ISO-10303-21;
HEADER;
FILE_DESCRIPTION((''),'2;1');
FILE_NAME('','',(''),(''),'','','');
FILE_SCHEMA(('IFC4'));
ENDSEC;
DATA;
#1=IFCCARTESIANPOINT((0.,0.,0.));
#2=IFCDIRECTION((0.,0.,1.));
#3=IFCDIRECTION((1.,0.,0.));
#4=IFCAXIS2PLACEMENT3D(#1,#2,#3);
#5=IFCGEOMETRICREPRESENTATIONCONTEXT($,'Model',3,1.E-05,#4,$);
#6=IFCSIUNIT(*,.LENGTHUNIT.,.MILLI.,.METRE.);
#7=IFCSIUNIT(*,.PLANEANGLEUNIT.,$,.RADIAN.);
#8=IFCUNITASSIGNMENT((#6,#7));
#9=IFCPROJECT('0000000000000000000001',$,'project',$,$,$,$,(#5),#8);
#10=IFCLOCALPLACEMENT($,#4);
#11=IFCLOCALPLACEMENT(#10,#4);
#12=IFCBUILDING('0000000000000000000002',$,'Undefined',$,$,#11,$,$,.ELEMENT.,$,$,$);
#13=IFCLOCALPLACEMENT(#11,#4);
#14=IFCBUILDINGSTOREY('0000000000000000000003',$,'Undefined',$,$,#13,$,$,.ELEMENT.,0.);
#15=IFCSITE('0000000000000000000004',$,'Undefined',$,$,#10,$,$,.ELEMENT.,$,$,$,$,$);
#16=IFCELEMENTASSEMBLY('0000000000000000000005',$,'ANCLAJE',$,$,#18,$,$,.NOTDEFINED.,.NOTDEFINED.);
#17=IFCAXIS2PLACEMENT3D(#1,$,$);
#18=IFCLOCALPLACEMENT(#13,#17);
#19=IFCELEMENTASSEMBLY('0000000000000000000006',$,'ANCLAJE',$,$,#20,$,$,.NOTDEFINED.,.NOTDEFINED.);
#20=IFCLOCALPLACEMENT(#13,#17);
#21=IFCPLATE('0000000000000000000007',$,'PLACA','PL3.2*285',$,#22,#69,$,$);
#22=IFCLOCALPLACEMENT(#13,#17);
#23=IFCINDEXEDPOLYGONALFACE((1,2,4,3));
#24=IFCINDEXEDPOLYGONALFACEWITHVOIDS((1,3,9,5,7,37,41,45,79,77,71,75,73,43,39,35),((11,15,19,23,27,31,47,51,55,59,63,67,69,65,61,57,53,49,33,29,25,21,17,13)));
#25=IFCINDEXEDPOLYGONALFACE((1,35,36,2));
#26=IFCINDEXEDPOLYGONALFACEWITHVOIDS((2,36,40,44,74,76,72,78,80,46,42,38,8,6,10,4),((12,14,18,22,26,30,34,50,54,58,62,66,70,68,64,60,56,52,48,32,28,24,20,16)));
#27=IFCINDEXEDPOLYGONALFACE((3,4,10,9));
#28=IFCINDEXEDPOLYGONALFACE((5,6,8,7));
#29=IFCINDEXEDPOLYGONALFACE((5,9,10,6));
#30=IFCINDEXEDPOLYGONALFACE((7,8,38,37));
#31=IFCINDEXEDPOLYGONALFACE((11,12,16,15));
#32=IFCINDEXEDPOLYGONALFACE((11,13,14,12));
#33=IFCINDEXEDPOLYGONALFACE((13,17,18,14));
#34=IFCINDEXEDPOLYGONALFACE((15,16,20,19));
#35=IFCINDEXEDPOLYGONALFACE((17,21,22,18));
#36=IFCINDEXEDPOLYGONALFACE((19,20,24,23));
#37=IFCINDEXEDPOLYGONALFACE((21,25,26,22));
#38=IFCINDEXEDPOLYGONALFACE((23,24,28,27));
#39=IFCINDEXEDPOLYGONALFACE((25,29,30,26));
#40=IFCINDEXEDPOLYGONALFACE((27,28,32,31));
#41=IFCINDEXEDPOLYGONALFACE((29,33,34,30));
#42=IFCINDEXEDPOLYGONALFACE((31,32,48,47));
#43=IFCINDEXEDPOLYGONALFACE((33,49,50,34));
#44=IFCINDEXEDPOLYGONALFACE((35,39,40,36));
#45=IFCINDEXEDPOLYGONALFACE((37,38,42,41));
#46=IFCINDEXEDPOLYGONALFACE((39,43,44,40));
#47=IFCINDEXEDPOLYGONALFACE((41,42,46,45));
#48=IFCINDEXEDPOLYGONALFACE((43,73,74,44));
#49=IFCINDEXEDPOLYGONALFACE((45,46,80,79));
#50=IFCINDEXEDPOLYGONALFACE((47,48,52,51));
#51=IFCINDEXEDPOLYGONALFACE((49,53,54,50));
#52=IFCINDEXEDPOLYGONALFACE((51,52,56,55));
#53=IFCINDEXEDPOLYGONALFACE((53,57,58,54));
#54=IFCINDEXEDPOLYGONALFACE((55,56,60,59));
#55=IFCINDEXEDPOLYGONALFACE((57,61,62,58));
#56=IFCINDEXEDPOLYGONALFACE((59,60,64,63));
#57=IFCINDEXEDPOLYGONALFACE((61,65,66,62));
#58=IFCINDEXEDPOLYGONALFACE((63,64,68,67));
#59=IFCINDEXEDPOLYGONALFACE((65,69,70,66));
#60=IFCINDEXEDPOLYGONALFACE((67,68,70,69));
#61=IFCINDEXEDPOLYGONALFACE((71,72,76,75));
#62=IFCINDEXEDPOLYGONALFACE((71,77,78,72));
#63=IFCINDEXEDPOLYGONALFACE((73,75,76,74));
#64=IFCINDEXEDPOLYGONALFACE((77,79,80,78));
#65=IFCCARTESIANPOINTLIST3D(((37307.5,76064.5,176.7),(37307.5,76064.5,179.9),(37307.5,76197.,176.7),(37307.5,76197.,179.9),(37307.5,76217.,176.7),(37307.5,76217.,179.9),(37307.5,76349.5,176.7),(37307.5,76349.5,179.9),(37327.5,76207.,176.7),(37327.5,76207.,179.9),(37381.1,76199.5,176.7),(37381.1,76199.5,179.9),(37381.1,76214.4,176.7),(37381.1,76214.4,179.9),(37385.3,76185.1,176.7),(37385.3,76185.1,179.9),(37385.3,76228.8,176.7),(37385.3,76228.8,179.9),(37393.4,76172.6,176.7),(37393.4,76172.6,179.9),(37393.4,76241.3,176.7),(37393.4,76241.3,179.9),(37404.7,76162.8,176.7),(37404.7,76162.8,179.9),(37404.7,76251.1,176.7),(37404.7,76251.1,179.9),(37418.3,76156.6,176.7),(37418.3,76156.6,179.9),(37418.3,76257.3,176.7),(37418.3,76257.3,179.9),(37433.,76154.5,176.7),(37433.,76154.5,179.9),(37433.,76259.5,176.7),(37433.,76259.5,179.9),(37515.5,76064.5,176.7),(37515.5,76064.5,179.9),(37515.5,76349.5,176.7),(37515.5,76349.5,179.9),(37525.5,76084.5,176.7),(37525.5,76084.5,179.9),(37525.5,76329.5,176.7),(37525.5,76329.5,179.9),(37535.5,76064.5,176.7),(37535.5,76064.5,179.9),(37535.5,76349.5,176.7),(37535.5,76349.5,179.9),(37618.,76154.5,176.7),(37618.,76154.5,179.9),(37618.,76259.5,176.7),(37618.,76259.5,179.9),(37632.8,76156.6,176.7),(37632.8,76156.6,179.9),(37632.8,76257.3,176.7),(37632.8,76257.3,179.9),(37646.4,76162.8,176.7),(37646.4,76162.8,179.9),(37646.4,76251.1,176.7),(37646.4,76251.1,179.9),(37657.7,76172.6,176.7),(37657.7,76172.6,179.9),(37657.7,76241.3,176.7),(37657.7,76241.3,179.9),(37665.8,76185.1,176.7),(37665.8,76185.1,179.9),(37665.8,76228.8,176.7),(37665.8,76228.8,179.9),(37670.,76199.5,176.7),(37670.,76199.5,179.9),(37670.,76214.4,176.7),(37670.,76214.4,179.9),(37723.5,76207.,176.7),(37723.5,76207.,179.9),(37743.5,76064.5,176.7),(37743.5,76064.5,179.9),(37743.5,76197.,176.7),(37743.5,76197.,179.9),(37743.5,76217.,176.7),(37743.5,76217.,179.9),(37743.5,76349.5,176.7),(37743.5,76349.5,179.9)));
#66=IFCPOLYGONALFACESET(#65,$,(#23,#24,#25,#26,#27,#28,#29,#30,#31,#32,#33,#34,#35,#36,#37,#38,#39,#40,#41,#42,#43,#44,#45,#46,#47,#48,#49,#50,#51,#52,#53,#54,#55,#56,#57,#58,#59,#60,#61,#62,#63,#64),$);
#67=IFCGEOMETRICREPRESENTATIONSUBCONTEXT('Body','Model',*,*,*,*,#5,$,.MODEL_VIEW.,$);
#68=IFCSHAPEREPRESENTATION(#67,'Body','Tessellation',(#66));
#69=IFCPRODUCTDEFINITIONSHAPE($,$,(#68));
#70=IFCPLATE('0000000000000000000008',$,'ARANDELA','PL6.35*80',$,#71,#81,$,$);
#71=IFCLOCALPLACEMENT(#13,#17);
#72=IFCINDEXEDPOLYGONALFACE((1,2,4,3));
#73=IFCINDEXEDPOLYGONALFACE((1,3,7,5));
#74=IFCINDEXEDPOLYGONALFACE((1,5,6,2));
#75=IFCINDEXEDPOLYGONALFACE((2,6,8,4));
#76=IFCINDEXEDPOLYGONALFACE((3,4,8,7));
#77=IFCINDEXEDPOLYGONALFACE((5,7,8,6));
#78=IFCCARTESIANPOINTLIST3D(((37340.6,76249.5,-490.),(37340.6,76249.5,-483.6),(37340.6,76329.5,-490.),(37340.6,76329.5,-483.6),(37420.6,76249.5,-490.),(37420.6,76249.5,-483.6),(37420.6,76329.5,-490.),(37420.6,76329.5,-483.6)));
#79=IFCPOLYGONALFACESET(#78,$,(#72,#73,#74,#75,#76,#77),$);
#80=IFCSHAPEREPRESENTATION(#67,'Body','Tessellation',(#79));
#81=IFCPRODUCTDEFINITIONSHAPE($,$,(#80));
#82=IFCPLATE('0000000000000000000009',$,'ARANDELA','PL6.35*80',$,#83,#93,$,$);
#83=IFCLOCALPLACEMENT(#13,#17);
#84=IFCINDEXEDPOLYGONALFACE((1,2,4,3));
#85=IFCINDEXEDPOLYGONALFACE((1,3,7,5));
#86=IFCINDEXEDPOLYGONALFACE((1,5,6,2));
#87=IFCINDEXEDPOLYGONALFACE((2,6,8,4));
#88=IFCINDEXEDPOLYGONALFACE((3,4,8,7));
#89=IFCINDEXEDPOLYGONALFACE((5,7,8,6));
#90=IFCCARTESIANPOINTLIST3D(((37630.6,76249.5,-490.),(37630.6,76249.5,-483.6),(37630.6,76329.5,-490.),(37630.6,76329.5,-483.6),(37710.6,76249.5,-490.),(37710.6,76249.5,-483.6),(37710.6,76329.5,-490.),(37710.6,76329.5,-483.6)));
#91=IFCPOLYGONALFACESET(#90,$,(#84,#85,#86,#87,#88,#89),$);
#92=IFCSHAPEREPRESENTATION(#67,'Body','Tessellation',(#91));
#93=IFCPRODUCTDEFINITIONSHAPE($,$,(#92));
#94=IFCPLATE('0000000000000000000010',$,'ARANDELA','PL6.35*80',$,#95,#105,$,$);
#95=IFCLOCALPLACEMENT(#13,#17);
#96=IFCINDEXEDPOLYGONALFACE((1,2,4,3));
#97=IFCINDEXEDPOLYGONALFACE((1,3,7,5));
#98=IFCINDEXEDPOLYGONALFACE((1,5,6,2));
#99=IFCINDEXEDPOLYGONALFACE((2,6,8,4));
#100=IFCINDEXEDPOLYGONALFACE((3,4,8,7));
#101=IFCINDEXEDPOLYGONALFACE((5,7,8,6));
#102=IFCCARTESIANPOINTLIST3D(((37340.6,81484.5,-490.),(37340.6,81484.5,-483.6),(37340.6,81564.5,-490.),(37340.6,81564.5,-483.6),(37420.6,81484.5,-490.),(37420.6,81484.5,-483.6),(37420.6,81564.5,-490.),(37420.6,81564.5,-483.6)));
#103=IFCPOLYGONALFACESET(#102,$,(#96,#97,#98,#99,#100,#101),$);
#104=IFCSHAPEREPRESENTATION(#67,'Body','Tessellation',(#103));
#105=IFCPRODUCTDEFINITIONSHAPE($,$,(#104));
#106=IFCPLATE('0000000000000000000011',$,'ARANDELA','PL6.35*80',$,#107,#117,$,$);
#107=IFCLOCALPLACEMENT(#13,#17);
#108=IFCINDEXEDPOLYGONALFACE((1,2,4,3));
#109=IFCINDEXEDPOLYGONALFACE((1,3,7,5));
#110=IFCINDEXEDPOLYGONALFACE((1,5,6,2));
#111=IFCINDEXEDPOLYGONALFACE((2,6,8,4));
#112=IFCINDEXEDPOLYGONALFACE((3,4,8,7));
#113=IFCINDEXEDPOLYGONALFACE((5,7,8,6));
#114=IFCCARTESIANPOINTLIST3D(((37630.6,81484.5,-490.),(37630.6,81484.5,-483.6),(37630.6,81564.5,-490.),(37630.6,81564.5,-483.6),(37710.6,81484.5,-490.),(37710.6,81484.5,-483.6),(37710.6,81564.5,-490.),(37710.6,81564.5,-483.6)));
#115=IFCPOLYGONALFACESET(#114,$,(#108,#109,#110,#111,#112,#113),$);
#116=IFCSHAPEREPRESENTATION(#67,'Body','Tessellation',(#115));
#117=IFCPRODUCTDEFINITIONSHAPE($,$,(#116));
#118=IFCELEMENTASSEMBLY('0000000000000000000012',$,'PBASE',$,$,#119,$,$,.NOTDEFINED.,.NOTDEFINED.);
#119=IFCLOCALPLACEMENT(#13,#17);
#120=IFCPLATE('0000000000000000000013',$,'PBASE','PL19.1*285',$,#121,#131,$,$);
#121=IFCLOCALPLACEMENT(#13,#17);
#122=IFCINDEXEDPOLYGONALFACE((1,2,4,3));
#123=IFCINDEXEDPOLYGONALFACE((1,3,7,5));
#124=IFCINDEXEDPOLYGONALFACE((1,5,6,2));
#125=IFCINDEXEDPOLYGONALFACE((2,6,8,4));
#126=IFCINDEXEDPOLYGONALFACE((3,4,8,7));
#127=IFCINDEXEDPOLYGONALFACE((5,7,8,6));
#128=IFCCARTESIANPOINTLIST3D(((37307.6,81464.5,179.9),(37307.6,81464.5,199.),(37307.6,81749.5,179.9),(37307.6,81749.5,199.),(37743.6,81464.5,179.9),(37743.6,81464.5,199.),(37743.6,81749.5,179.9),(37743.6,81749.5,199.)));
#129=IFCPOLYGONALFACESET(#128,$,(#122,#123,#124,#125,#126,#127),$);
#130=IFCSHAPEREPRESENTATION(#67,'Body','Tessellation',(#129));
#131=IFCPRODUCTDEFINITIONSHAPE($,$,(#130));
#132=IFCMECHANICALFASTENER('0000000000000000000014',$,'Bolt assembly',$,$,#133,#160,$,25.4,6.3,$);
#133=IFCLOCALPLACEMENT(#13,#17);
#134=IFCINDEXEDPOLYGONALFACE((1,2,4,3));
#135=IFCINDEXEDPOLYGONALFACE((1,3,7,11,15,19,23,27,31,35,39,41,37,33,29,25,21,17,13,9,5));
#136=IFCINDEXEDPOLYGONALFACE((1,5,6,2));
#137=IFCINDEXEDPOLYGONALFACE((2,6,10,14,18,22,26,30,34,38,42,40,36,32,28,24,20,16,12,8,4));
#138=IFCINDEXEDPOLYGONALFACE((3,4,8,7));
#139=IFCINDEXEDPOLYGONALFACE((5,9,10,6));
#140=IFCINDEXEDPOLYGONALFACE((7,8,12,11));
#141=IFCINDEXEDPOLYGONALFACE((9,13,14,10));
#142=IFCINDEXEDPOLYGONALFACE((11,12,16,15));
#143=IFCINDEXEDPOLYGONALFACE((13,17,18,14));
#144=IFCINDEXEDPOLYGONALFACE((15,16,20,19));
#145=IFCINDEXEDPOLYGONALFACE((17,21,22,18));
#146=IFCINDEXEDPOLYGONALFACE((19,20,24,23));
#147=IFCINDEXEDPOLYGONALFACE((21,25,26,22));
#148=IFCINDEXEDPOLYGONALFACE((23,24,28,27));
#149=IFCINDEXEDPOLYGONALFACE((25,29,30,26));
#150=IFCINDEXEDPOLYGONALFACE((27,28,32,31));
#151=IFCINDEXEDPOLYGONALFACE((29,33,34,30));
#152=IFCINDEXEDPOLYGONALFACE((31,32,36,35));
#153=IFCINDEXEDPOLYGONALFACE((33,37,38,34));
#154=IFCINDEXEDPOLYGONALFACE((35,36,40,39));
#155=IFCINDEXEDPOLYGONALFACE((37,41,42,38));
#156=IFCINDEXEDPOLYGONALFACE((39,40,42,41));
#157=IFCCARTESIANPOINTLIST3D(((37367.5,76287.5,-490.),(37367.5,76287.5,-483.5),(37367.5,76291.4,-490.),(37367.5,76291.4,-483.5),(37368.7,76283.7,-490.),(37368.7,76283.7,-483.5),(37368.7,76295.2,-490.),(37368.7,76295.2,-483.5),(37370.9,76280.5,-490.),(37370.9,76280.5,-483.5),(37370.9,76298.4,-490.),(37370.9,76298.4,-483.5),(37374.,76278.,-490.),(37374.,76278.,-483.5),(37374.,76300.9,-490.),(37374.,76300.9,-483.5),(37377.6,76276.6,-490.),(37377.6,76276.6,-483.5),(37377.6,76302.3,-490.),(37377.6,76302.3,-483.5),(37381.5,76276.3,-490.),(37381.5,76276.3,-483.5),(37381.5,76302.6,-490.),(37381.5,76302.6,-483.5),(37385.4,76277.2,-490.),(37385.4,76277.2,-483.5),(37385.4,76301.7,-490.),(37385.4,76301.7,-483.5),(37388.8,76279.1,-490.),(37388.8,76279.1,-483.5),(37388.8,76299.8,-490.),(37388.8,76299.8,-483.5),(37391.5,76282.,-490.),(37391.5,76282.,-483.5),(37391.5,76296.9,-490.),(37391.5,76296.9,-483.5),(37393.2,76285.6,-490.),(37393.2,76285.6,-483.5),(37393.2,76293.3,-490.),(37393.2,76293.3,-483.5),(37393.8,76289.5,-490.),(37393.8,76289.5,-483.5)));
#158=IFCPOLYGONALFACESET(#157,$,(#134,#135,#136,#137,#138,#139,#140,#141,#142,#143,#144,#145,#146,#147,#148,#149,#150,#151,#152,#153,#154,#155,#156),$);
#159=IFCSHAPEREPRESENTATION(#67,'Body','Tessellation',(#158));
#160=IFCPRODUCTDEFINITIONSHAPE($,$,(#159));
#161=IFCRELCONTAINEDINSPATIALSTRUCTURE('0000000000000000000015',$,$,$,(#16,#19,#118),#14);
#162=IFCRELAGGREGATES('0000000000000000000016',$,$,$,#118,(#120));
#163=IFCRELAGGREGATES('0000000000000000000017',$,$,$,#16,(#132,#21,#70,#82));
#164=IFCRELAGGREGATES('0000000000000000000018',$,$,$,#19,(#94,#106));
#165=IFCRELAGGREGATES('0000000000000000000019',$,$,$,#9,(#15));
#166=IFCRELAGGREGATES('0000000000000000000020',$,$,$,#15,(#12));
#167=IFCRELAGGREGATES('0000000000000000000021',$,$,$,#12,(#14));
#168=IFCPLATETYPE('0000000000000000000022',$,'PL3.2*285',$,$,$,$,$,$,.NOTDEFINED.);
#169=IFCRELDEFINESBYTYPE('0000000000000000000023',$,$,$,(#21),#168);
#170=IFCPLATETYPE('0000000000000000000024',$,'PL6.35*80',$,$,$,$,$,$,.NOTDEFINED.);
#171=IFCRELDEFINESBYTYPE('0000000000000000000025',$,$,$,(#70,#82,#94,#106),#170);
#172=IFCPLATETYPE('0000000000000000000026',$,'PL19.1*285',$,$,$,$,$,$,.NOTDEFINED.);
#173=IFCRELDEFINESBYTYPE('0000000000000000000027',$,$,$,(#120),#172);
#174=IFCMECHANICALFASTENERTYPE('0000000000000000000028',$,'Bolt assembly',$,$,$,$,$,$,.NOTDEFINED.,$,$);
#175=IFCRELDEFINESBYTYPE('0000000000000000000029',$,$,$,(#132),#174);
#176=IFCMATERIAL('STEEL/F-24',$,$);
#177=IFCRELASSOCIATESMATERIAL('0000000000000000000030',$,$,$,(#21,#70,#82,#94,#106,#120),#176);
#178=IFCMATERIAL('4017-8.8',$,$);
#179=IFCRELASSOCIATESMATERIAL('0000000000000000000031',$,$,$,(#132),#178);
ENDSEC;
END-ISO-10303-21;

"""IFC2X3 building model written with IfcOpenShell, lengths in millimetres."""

from ifc_helpers import new_model, si_unit, frame, frame_2d, origin_with_axes, origin_2d_with_axis, place, context, subcontext, project, spatial, polyline, circle_curve, parameter, trimmed, segment, composite_curve, circle, outline, extrude, boolean, source, transform, mapped, material, type_object, element, aggregate, save


model = new_model("IFC2X3")

# Units and contexts
model_context = context("Model", 3, precision=1e-05, world=origin_with_axes())
body_context = subcontext(model_context, "Body", "Model", "MODEL_VIEW")
ifc_project = project(units=[si_unit("LENGTHUNIT", "METRE", prefix="MILLI"), si_unit("PLANEANGLEUNIT", "RADIAN")], contexts=[model_context])

# Site, building, storey
site_placement = place(None, origin_with_axes())
site = spatial("IfcSite", under=ifc_project, at=site_placement, Name="Undefined", CompositionType="ELEMENT")
building_placement = place(site_placement, origin_with_axes())
building = spatial("IfcBuilding", under=site, at=building_placement, Name="Undefined", CompositionType="ELEMENT")
storey_placement = place(building_placement, origin_with_axes())
storey = spatial("IfcBuildingStorey", under=building, at=storey_placement, Name="Undefined", CompositionType="ELEMENT", Elevation=0.0)

# Element assemblies
assembly_1_placement = place(storey_placement, origin_with_axes())
assembly_1 = element("IfcElementAssembly", 1, at=assembly_1_placement, inside=storey, Name="ANCLAJE", AssemblyPlace="NOTDEFINED", PredefinedType="NOTDEFINED")
assembly_2_placement = place(storey_placement, origin_with_axes())
assembly_2 = element("IfcElementAssembly", 2, at=assembly_2_placement, inside=storey, Name="ANCLAJE", AssemblyPlace="NOTDEFINED", PredefinedType="NOTDEFINED")

# Plates
ifc_material_1 = material(Name="STEEL/F-24")
plate_type_1 = type_object("IfcPlateType", Name="PL3.2*285", PredefinedType="NOTDEFINED")
plate_1_placement = place(assembly_1_placement, frame((37743.5, 76349.5, 178.3), z_axis=(0.0, 0.0, 1.0), x_axis=(-1.0, 0.0, 0.0)))
plate_1 = element("IfcPlate", 3, at=plate_1_placement, type_object=plate_type_1, material=ifc_material_1, Name="PLACA", Description="PL3.2*285", context=body_context, shape_type="CSG", body=[
    boolean("DIFFERENCE", boolean("DIFFERENCE", boolean("DIFFERENCE", boolean("DIFFERENCE", boolean("DIFFERENCE", extrude(outline(polyline([(0.0, 0.0), (436.0, 0.0), (436.0, 285.0), (0.0, 285.0), (0.0, 0.0)])), frame((0.0, 0.0, -1.6), z_axis=(0.0, 0.0, 1.0), x_axis=(1.0, 0.0, 0.0)), (0.0, 0.0, 1.0), 3.2), extrude(outline(composite_curve([segment(trimmed(circle_curve(frame_2d((52.5, 52.5), x_axis=(-1.0, 0.0)), 52.5), [parameter(0.0)], [parameter(1.570796)], True, "PARAMETER"), True, "CONTINUOUS"), segment(polyline([(52.5, 0.0), (237.5, 0.0)]), True, "CONTINUOUS"), segment(trimmed(circle_curve(frame_2d((237.5, 52.5), x_axis=(0.0, -1.0)), 52.5), [parameter(0.0)], [parameter(1.570796)], True, "PARAMETER"), True, "CONTINUOUS"), segment(polyline([(290.0, 52.5), (290.0, 52.5)]), True, "CONTINUOUS"), segment(trimmed(circle_curve(frame_2d((237.5, 52.5), x_axis=(1.0, 0.0)), 52.5), [parameter(0.0)], [parameter(1.570796)], True, "PARAMETER"), True, "CONTINUOUS"), segment(polyline([(237.5, 105.0), (52.5, 105.0)]), True, "CONTINUOUS"), segment(trimmed(circle_curve(frame_2d((52.5, 52.5), x_axis=(0.0, 1.0)), 52.5), [parameter(0.0)], [parameter(1.570796)], True, "PARAMETER"), True, "CONTINUOUS"), segment(polyline([(0.0, 52.5), (0.0, 52.5)]), True, "CONTINUOUS")], self_intersect=True)), frame((363.0, 90.0, 7.5), z_axis=(0.0, 0.0, -1.0), x_axis=(-1.0, 0.0, 0.0)), (0.0, 0.0, 1.0), 15.0)), extrude(outline(polyline([(0.0, 0.0), (20.0, 0.0), (10.0, 20.0), (0.0, 0.0)])), frame((0.0, 152.5, -7.5), z_axis=(0.0, 0.0, 1.0), x_axis=(0.0, -1.0, 0.0)), (0.0, 0.0, 1.0), 15.0)), extrude(outline(polyline([(0.0, 0.0), (20.0, 0.0), (10.0, 20.0), (0.0, 0.0)])), frame((436.0, 152.5, 7.5), z_axis=(0.0, 0.0, -1.0), x_axis=(0.0, -1.0, 0.0)), (0.0, 0.0, 1.0), 15.0)), extrude(outline(polyline([(0.0, 0.0), (20.0, 0.0), (10.0, 20.0), (0.0, 0.0)])), frame((228.0, 285.0, -7.5), z_axis=(0.0, 0.0, 1.0), x_axis=(-1.0, 0.0, 0.0)), (0.0, 0.0, 1.0), 15.0)), extrude(outline(polyline([(0.0, 0.0), (20.0, 0.0), (10.0, 20.0), (0.0, 0.0)])), frame((228.0, 0.0, 7.5), z_axis=(0.0, 0.0, -1.0), x_axis=(-1.0, 0.0, 0.0)), (0.0, 0.0, 1.0), 15.0)),
])
plate_type_2 = type_object("IfcPlateType", Name="PL6.35*80", PredefinedType="NOTDEFINED")
plate_2_placement = place(assembly_1_placement, frame((37340.6, 76289.5, -486.8), z_axis=(0.0, 0.0, -1.0), x_axis=(1.0, 0.0, 0.0)))
plate_2 = element("IfcPlate", 4, at=plate_2_placement, type_object=plate_type_2, material=ifc_material_1, Name="ARANDELA", Description="PL6.35*80", context=body_context, shape_type="SweptSolid", body=[
    extrude(outline(polyline([(0.0, -40.0), (0.0, 40.0), (80.0, 40.0), (80.0, -40.0), (0.0, -40.0)])), frame((0.0, 0.0, -3.2), z_axis=(0.0, 0.0, 1.0), x_axis=(1.0, 0.0, 0.0)), (0.0, 0.0, 1.0), 6.4),
])
plate_3_placement = place(assembly_1_placement, frame((37630.6, 76289.5, -486.8), z_axis=(0.0, 0.0, -1.0), x_axis=(1.0, 0.0, 0.0)))
plate_3 = element("IfcPlate", 5, at=plate_3_placement, type_object=plate_type_2, material=ifc_material_1, Name="ARANDELA", Description="PL6.35*80", context=body_context, shape_type="SweptSolid", body=[
    extrude(outline(polyline([(0.0, -40.0), (0.0, 40.0), (80.0, 40.0), (80.0, -40.0), (0.0, -40.0)])), frame((0.0, 0.0, -3.2), z_axis=(0.0, 0.0, 1.0), x_axis=(1.0, 0.0, 0.0)), (0.0, 0.0, 1.0), 6.4),
])
plate_4_placement = place(assembly_2_placement, frame((37340.6, 81524.5, -486.8), z_axis=(0.0, 0.0, -1.0), x_axis=(1.0, 0.0, 0.0)))
plate_4 = element("IfcPlate", 6, at=plate_4_placement, type_object=plate_type_2, material=ifc_material_1, Name="ARANDELA", Description="PL6.35*80", context=body_context, shape_type="SweptSolid", body=[
    extrude(outline(polyline([(0.0, -40.0), (0.0, 40.0), (80.0, 40.0), (80.0, -40.0), (0.0, -40.0)])), frame((0.0, 0.0, -3.2), z_axis=(0.0, 0.0, 1.0), x_axis=(1.0, 0.0, 0.0)), (0.0, 0.0, 1.0), 6.4),
])
plate_5_placement = place(assembly_2_placement, frame((37630.6, 81524.5, -486.8), z_axis=(0.0, 0.0, -1.0), x_axis=(1.0, 0.0, 0.0)))
plate_5 = element("IfcPlate", 7, at=plate_5_placement, type_object=plate_type_2, material=ifc_material_1, Name="ARANDELA", Description="PL6.35*80", context=body_context, shape_type="SweptSolid", body=[
    extrude(outline(polyline([(0.0, -40.0), (0.0, 40.0), (80.0, 40.0), (80.0, -40.0), (0.0, -40.0)])), frame((0.0, 0.0, -3.2), z_axis=(0.0, 0.0, 1.0), x_axis=(1.0, 0.0, 0.0)), (0.0, 0.0, 1.0), 6.4),
])

# Element assembly, plate
assembly_3_placement = place(storey_placement, origin_with_axes())
assembly_3 = element("IfcElementAssembly", 8, at=assembly_3_placement, inside=storey, Name="PBASE", AssemblyPlace="NOTDEFINED", PredefinedType="NOTDEFINED")
plate_type_3 = type_object("IfcPlateType", Name="PL19.1*285", PredefinedType="NOTDEFINED")
plate_6_placement = place(assembly_3_placement, frame((37743.6, 81607.0, 189.5), z_axis=(0.0, 0.0, 1.0), x_axis=(-1.0, 0.0, 0.0)))
plate_6 = element("IfcPlate", 9, at=plate_6_placement, type_object=plate_type_3, material=ifc_material_1, Name="PBASE", Description="PL19.1*285", context=body_context, shape_type="SweptSolid", body=[
    extrude(outline(polyline([(0.0, -142.5), (0.0, 142.5), (436.0, 142.5), (436.0, -142.5), (0.0, -142.5)])), frame((0.0, 0.0, -9.6), z_axis=(0.0, 0.0, 1.0), x_axis=(1.0, 0.0, 0.0)), (0.0, 0.0, 1.0), 19.1),
])
aggregate(assembly_3, [plate_6])

# Mechanical fastener
ifc_material_2 = material(Name="4017-8.8")
mechanical_fastener_type = type_object("IfcMechanicalFastenerType", Name="Bolt assembly")
shared_shape_1 = source(origin_with_axes(), body_context, "Body", "SweptSolid", [
    extrude(circle(Radius=13.2, at=origin_2d_with_axis()), frame((0.0, 0.0, 0.0), z_axis=(0.0, 1.0, 0.0), x_axis=(1.0, 0.0, 0.0)), (0.0, 0.0, 1.0), 6.5),
])
mechanical_fastener_1_placement = place(assembly_1_placement, frame((37380.6, 76289.5, -490.0), z_axis=(0.0, -1.0, 0.0), x_axis=(1.0, 0.0, 0.0)))
mechanical_fastener_1 = element("IfcMechanicalFastener", 10, at=mechanical_fastener_1_placement, type_object=mechanical_fastener_type, material=ifc_material_2, Name="Bolt assembly", NominalDiameter=25.4, NominalLength=6.3, context=body_context, shape_type="MappedRepresentation", body=[
    mapped(shared_shape_1, transform((0.0, 0.0, 0.0))),
])
aggregate(assembly_1, [mechanical_fastener_1, plate_1, plate_2, plate_3])
aggregate(assembly_2, [plate_4, plate_5])

save(model, "model.ifc")
